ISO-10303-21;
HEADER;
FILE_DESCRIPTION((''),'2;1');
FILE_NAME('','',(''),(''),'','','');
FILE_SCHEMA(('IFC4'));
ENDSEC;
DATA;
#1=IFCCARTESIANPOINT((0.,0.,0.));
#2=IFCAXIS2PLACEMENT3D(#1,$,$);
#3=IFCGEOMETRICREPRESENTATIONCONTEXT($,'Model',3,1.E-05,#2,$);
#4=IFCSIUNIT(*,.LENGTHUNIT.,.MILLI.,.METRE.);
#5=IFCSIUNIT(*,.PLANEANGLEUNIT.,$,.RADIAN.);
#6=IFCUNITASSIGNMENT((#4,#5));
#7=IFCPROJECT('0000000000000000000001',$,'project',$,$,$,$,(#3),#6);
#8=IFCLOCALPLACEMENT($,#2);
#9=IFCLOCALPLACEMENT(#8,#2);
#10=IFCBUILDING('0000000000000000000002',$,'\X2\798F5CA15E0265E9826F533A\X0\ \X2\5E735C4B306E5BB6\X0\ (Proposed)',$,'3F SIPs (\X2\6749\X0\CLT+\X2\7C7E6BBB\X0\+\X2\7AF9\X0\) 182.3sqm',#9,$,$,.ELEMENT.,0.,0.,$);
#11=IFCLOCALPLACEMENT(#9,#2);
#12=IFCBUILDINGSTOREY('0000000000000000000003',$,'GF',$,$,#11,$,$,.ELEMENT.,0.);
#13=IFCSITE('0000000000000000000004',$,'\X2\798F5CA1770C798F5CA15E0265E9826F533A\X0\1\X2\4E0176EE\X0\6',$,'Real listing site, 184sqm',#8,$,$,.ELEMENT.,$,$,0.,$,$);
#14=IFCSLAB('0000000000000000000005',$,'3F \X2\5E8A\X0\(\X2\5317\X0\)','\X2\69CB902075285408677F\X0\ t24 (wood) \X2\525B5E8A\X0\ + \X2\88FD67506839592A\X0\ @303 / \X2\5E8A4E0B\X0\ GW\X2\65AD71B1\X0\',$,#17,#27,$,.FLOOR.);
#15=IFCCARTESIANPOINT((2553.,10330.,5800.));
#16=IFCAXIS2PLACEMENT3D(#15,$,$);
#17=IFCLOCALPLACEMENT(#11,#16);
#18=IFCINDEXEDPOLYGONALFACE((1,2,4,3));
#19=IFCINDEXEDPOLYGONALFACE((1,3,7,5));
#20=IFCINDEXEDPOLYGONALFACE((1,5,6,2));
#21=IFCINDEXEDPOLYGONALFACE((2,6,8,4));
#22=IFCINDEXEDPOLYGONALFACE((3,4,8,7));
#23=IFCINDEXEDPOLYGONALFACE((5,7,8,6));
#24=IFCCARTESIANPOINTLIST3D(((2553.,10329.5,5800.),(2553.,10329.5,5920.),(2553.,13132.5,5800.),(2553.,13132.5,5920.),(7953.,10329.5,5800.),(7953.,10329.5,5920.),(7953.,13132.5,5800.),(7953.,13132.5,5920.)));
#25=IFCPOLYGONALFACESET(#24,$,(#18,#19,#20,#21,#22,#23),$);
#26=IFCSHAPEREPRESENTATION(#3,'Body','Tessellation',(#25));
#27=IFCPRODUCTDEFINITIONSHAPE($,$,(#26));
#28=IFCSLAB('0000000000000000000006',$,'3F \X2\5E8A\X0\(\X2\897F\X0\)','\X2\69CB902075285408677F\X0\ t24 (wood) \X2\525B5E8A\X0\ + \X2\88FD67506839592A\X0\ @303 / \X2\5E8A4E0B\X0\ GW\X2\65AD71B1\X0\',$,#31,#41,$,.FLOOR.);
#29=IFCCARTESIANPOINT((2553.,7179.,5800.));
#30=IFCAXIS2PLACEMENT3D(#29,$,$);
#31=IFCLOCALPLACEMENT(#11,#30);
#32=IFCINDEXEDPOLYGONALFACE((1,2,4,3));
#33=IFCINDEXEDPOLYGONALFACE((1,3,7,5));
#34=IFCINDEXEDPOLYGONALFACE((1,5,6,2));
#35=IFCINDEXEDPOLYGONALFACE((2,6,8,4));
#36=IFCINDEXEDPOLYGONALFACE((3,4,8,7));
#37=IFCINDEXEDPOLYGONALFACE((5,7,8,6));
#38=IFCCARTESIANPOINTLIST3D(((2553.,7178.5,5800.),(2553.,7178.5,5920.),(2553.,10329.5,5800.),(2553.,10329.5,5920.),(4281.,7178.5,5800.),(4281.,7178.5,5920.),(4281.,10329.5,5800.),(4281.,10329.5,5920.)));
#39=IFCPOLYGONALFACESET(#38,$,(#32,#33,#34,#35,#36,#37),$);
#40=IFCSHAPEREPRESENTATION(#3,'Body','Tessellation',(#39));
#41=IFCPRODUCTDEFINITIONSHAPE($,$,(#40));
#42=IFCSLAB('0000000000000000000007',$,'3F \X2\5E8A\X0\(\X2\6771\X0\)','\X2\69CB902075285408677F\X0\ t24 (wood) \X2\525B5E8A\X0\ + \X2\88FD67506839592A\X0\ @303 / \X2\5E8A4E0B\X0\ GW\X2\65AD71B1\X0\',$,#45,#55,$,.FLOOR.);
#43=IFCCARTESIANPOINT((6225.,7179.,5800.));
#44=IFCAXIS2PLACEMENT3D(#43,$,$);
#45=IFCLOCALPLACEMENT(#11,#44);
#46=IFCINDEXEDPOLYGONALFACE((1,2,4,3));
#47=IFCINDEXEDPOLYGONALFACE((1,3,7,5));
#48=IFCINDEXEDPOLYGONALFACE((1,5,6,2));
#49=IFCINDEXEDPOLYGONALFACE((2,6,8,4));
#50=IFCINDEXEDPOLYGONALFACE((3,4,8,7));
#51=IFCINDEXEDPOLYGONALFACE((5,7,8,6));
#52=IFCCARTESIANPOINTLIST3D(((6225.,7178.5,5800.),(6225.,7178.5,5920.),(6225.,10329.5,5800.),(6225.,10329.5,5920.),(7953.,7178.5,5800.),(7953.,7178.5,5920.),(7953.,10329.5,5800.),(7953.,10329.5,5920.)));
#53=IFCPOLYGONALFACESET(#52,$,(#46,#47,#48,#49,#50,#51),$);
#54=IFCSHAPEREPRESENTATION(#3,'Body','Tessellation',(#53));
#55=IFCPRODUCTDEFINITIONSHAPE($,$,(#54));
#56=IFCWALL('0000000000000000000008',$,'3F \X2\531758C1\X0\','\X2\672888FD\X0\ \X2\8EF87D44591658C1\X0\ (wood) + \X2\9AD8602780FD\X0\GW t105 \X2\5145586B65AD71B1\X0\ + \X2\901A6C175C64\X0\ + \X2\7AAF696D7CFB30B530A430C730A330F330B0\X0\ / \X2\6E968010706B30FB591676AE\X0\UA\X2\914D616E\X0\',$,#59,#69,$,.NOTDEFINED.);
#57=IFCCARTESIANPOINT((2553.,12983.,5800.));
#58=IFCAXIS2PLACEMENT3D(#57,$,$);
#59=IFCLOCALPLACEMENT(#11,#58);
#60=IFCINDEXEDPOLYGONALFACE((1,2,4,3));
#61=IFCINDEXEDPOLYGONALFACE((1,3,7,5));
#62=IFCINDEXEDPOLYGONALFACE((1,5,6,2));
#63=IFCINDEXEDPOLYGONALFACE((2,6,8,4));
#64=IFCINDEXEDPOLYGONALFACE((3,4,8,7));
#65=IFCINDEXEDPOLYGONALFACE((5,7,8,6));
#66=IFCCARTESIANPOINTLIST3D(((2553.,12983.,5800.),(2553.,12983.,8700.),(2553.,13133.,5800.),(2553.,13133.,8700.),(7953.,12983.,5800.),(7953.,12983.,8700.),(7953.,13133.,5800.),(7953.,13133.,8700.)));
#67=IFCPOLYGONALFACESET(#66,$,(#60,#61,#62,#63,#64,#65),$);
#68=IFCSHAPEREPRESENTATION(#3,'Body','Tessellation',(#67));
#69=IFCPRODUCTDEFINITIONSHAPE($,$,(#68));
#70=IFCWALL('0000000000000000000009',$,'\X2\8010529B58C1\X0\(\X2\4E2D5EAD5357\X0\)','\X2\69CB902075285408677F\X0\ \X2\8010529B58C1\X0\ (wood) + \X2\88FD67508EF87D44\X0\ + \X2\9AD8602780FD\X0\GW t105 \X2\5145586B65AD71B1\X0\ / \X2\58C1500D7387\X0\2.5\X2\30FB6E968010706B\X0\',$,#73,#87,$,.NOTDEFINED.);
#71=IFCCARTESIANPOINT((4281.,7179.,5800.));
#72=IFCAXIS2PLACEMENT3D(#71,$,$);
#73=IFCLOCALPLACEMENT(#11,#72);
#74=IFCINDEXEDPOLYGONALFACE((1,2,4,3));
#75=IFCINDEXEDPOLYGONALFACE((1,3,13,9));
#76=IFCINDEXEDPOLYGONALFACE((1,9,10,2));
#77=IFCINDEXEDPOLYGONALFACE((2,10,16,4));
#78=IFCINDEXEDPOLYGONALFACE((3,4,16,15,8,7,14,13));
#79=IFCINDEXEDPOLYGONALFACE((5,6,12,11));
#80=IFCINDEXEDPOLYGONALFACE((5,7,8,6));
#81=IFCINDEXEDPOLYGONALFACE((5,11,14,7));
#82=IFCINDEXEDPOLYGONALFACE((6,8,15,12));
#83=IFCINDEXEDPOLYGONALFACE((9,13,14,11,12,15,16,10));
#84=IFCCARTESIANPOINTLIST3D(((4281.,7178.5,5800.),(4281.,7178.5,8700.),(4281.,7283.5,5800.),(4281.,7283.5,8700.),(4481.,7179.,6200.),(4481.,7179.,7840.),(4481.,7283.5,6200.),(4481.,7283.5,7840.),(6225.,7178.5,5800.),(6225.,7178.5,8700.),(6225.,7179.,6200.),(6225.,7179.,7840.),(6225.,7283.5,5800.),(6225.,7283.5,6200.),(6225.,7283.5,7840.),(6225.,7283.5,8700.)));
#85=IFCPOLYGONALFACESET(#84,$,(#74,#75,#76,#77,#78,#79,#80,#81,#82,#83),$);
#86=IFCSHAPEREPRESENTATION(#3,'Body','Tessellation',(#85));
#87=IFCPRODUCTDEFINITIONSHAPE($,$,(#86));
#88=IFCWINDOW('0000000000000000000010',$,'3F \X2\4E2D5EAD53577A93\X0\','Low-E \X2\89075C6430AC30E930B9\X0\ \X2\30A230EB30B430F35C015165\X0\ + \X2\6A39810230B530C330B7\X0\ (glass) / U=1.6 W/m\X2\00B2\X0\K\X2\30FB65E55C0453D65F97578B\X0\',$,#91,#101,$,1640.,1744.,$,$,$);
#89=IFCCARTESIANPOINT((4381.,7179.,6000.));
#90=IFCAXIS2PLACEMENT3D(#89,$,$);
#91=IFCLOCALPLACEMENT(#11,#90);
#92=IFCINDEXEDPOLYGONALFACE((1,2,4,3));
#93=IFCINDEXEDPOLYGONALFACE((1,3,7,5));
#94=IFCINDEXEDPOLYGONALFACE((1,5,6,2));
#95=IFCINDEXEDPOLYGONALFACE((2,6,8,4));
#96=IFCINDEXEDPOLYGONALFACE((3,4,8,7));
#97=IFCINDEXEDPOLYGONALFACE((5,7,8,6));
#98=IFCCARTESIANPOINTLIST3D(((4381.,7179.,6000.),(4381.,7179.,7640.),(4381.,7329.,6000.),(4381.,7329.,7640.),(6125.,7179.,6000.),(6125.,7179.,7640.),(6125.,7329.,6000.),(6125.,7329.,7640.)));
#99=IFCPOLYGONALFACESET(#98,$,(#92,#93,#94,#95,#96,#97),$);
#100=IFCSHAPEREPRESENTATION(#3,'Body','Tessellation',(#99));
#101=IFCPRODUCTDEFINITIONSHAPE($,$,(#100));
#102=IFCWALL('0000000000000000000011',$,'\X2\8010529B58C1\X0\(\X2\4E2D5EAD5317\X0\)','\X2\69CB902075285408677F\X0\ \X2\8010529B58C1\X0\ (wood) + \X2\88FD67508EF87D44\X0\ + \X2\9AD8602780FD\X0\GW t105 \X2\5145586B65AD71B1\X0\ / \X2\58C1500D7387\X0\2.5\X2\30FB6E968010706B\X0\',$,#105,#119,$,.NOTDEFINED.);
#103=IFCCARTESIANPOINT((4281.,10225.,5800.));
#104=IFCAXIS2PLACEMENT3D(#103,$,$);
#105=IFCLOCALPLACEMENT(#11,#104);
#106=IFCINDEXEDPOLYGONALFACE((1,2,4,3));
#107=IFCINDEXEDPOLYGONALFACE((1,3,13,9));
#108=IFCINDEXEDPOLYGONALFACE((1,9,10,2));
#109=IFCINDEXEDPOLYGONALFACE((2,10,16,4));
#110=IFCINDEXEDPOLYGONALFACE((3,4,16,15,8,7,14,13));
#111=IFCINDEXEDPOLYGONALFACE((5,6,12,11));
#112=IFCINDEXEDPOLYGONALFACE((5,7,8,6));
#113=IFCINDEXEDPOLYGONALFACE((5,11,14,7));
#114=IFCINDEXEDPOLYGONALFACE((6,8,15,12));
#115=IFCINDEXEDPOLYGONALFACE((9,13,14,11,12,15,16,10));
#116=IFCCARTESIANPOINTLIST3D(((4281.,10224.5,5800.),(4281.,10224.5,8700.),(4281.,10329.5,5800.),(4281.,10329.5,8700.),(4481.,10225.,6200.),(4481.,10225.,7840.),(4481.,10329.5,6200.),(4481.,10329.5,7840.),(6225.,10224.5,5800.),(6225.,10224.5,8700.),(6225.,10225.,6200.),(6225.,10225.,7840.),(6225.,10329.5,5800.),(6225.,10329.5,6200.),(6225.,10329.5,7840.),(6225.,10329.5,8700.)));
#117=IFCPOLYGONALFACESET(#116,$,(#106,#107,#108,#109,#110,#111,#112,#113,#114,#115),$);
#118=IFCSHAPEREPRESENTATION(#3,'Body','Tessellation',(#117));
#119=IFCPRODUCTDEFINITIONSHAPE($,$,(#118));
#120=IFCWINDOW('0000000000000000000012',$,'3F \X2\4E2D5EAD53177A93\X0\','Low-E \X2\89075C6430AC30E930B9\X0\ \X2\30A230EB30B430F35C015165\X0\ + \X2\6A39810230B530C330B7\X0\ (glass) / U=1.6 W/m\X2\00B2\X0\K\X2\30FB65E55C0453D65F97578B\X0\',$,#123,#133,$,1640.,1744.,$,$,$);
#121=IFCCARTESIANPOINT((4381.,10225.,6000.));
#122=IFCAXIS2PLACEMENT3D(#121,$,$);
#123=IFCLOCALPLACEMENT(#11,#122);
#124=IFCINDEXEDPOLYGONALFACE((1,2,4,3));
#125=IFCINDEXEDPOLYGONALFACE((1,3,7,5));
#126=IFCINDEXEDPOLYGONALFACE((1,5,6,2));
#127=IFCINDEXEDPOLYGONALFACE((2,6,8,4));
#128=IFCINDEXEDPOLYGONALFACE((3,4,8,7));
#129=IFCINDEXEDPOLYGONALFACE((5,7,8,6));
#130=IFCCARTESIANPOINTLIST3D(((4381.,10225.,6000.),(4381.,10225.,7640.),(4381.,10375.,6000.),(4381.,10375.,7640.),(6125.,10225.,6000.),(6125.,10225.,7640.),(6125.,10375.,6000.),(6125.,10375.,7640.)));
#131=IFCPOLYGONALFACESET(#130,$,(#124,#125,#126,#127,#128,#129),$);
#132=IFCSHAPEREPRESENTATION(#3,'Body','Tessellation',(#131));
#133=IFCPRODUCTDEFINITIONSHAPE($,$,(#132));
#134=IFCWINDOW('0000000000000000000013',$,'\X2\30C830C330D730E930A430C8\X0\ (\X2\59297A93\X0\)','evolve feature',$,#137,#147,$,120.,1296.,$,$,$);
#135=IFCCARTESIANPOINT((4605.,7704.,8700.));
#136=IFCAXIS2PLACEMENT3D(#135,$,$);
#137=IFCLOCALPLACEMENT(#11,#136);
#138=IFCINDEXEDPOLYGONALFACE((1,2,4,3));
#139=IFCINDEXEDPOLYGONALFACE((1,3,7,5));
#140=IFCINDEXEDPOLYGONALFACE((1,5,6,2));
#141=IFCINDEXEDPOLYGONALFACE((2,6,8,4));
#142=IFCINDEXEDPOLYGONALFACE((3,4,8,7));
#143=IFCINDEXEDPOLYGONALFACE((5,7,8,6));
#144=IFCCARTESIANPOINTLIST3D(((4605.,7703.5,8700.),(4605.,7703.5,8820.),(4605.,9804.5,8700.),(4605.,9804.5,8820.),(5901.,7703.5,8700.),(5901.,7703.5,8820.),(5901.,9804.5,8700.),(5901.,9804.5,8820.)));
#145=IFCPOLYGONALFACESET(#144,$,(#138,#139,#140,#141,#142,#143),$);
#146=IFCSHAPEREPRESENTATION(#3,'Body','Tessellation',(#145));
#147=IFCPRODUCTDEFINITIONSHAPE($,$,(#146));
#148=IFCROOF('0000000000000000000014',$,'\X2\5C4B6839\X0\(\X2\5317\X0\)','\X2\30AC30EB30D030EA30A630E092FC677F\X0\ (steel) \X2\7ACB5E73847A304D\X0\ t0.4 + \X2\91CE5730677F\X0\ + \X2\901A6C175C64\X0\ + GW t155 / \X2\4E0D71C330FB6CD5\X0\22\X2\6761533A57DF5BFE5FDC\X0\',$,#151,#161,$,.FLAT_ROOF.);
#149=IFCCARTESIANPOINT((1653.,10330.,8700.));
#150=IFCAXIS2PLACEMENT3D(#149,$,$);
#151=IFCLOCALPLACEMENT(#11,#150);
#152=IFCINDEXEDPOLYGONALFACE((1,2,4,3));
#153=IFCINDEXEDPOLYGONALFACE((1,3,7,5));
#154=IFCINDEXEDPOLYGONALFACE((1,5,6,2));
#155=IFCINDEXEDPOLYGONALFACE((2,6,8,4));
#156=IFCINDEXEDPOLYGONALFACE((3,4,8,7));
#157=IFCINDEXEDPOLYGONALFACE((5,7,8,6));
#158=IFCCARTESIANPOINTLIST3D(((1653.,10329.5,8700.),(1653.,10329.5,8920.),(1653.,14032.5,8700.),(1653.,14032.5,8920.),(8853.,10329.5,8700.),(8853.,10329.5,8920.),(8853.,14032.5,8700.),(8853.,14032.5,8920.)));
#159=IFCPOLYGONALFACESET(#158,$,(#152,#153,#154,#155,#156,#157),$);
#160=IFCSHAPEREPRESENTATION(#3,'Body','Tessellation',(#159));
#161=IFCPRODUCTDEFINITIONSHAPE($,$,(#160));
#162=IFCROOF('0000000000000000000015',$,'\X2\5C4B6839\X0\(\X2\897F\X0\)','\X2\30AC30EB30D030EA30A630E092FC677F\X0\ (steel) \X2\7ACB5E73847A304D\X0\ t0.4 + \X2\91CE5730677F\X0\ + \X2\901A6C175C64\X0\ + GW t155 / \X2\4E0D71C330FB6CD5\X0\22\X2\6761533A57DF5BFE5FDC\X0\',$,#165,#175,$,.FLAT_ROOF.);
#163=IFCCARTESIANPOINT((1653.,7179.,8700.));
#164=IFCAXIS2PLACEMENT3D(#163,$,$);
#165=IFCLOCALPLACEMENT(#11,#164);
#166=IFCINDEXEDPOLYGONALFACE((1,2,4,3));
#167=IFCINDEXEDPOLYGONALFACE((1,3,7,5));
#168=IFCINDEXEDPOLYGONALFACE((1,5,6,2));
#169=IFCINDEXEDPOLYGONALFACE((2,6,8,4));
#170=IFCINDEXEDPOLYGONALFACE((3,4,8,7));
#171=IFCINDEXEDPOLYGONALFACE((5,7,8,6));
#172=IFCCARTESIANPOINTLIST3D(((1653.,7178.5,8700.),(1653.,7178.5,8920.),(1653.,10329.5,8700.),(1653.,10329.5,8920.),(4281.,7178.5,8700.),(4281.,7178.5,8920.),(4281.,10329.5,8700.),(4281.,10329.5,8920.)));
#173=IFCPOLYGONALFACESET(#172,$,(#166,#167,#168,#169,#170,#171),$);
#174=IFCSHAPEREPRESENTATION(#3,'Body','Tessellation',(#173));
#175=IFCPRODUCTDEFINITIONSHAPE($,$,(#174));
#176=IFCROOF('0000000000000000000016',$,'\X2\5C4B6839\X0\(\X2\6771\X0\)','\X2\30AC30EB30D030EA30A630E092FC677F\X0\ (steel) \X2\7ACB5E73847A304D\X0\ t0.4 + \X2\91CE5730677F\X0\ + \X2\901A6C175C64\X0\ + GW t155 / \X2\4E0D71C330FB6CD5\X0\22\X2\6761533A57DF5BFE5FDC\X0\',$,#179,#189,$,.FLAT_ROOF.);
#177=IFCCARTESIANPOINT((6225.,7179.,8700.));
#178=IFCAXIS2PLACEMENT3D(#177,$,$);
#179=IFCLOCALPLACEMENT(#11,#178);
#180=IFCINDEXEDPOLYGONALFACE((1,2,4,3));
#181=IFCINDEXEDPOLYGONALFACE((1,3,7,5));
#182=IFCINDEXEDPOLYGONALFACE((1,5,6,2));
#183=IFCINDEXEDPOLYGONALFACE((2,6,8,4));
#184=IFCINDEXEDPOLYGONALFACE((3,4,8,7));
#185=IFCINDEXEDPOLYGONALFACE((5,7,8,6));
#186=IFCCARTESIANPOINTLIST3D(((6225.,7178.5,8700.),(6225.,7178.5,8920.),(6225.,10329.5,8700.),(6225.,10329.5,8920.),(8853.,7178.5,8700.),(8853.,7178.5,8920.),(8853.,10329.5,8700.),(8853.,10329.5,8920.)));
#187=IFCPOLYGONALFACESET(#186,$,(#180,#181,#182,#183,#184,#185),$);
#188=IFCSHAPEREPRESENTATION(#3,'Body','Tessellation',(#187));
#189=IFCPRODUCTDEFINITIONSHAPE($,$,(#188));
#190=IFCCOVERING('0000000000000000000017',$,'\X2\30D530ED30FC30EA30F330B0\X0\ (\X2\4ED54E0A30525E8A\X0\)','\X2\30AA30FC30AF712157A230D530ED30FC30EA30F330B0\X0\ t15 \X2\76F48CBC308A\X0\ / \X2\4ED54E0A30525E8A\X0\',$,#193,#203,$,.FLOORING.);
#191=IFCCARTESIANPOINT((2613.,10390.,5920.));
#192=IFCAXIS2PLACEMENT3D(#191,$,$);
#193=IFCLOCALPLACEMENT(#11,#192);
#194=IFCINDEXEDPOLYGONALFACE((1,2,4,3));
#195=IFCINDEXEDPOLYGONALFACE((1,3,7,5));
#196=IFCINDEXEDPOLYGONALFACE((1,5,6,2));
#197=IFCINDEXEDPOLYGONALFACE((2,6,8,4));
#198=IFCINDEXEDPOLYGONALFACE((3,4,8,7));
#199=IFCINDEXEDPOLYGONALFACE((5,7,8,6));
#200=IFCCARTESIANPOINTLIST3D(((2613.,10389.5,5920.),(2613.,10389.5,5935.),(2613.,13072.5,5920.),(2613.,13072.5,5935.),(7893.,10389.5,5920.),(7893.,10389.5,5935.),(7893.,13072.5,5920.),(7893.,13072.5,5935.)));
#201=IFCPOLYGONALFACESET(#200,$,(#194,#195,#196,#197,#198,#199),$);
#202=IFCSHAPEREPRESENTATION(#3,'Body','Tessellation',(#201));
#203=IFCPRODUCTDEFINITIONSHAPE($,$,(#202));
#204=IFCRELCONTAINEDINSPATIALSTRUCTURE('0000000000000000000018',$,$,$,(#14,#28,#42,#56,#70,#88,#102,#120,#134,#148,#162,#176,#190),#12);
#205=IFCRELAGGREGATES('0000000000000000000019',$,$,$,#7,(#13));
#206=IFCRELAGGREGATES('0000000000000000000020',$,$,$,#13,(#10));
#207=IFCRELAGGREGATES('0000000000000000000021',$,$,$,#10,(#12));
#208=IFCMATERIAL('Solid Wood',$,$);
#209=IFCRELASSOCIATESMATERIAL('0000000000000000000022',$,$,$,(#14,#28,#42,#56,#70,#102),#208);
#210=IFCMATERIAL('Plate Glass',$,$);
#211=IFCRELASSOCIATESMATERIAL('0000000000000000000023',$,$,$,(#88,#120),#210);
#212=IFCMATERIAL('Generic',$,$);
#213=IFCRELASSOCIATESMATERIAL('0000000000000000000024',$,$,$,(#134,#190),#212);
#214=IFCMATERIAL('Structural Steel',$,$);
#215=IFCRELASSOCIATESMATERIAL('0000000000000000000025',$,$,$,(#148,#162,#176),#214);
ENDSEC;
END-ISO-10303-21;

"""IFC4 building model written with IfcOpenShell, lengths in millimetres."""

from ifc_helpers import new_model, si_unit, frame, frame_2d, origin, place, context, project, spatial, rectangle, extrude, material, element, fill, save


model = new_model("IFC4")

# Units and contexts
model_context = context("Model", 3, precision=1e-05, world=origin())
ifc_project = project(units=[si_unit("LENGTHUNIT", "METRE", prefix="MILLI"), si_unit("PLANEANGLEUNIT", "RADIAN")], contexts=[model_context])

# Site, building, storey
site_placement = place(None, origin())
site = spatial("IfcSite", under=ifc_project, at=site_placement, Name="福岡県福岡市早良区1丁目6", ObjectType="Real listing site, 184sqm", CompositionType="ELEMENT", RefElevation=0.0)
building_placement = place(site_placement, origin())
building = spatial("IfcBuilding", under=site, at=building_placement, Name="福岡市早良区 平屋の家 (Proposed)", ObjectType="3F SIPs (杉CLT+籾殻+竹) 182.3sqm", CompositionType="ELEMENT", ElevationOfRefHeight=0.0, ElevationOfTerrain=0.0)
storey_placement = place(building_placement, origin())
storey = spatial("IfcBuildingStorey", under=building, at=storey_placement, Name="GF", CompositionType="ELEMENT", Elevation=0.0)

# Slabs
ifc_material_1 = material(Name="Solid Wood")
slab_1_placement = place(storey_placement, frame((2553.0, 10330.0, 5800.0)))
element("IfcSlab", 1, at=slab_1_placement, inside=storey, material=ifc_material_1, Name="3F 床(北)", Description="構造用合板 t24 (wood) 剛床 + 製材根太 @303 / 床下 GW断熱", PredefinedType="FLOOR", context=model_context, shape_type="SweptSolid", body=[
    extrude(rectangle(XDim=5400.0, YDim=2803.0, at=frame_2d((2700.0, 1401.0))), frame((2553.0, 10330.0, 5800.0)), (0.0, 0.0, 1.0), 120.0),
])
slab_2_placement = place(storey_placement, frame((2553.0, 7179.0, 5800.0)))
element("IfcSlab", 2, at=slab_2_placement, inside=storey, material=ifc_material_1, Name="3F 床(西)", Description="構造用合板 t24 (wood) 剛床 + 製材根太 @303 / 床下 GW断熱", PredefinedType="FLOOR", context=model_context, shape_type="SweptSolid", body=[
    extrude(rectangle(XDim=1728.0, YDim=3151.0, at=frame_2d((864.0, 1575.0))), frame((2553.0, 7179.0, 5800.0)), (0.0, 0.0, 1.0), 120.0),
])
slab_3_placement = place(storey_placement, frame((6225.0, 7179.0, 5800.0)))
element("IfcSlab", 3, at=slab_3_placement, inside=storey, material=ifc_material_1, Name="3F 床(東)", Description="構造用合板 t24 (wood) 剛床 + 製材根太 @303 / 床下 GW断熱", PredefinedType="FLOOR", context=model_context, shape_type="SweptSolid", body=[
    extrude(rectangle(XDim=1728.0, YDim=3151.0, at=frame_2d((864.0, 1575.0))), frame((6225.0, 7179.0, 5800.0)), (0.0, 0.0, 1.0), 120.0),
])

# Wall
wall_1_placement = place(storey_placement, frame((2553.0, 12983.0, 5800.0)))
element("IfcWall", 4, at=wall_1_placement, inside=storey, material=ifc_material_1, Name="3F 北壁", Description="木製 軸組外壁 (wood) + 高性能GW t105 充填断熱 + 通気層 + 窯業系サイディング / 準耐火・外皮UA配慮", PredefinedType="NOTDEFINED", context=model_context, shape_type="SweptSolid", body=[
    extrude(rectangle(XDim=5400.0, YDim=150.0, at=frame_2d((2700.0, 75.0))), frame((2553.0, 12983.0, 5800.0)), (0.0, 0.0, 1.0), 2900.0),
])

# Walls, openings, windows
wall_2_placement = place(storey_placement, frame((4281.0, 7179.0, 5800.0)))
wall_2 = element("IfcWall", 5, at=wall_2_placement, inside=storey, material=ifc_material_1, Name="耐力壁(中庭南)", Description="構造用合板 耐力壁 (wood) + 製材軸組 + 高性能GW t105 充填断熱 / 壁倍率2.5・準耐火", PredefinedType="NOTDEFINED", context=model_context, shape_type="SweptSolid", body=[
    extrude(rectangle(XDim=1944.0, YDim=105.0, at=frame_2d((972.0, 52.0))), frame((4281.0, 7179.0, 5800.0)), (0.0, 0.0, 1.0), 2900.0),
])
opening_1_placement = place(storey_placement, frame((4381.0, 7179.0, 6000.0)))
opening_1 = element("IfcOpeningElement", 6, at=opening_1_placement, cuts=wall_2, PredefinedType="NOTDEFINED", context=model_context, shape_type="SweptSolid", body=[
    extrude(rectangle(XDim=1744.0, YDim=150.0, at=frame_2d((872.0, 75.0))), frame((4381.0, 7179.0, 6000.0)), (0.0, 0.0, 1.0), 1640.0),
])
ifc_material_2 = material(Name="Plate Glass")
window_1_placement = place(storey_placement, frame((4381.0, 7179.0, 6000.0)))
window_1 = element("IfcWindow", 7, at=window_1_placement, inside=storey, material=ifc_material_2, Name="3F 中庭南窓", Description="Low-E 複層ガラス アルゴン封入 + 樹脂サッシ (glass) / U=1.6 W/m²K・日射取得型", OverallHeight=1640.0, OverallWidth=1744.0, context=model_context, shape_type="SweptSolid", body=[
    extrude(rectangle(XDim=1744.0, YDim=150.0, at=frame_2d((872.0, 75.0))), frame((4381.0, 7179.0, 6000.0)), (0.0, 0.0, 1.0), 1640.0),
])
fill(opening_1, window_1)
wall_3_placement = place(storey_placement, frame((4281.0, 10225.0, 5800.0)))
wall_3 = element("IfcWall", 8, at=wall_3_placement, inside=storey, material=ifc_material_1, Name="耐力壁(中庭北)", Description="構造用合板 耐力壁 (wood) + 製材軸組 + 高性能GW t105 充填断熱 / 壁倍率2.5・準耐火", PredefinedType="NOTDEFINED", context=model_context, shape_type="SweptSolid", body=[
    extrude(rectangle(XDim=1944.0, YDim=105.0, at=frame_2d((972.0, 52.0))), frame((4281.0, 10225.0, 5800.0)), (0.0, 0.0, 1.0), 2900.0),
])
opening_2_placement = place(storey_placement, frame((4381.0, 10225.0, 6000.0)))
opening_2 = element("IfcOpeningElement", 9, at=opening_2_placement, cuts=wall_3, PredefinedType="NOTDEFINED", context=model_context, shape_type="SweptSolid", body=[
    extrude(rectangle(XDim=1744.0, YDim=150.0, at=frame_2d((872.0, 75.0))), frame((4381.0, 10225.0, 6000.0)), (0.0, 0.0, 1.0), 1640.0),
])
window_2_placement = place(storey_placement, frame((4381.0, 10225.0, 6000.0)))
window_2 = element("IfcWindow", 10, at=window_2_placement, inside=storey, material=ifc_material_2, Name="3F 中庭北窓", Description="Low-E 複層ガラス アルゴン封入 + 樹脂サッシ (glass) / U=1.6 W/m²K・日射取得型", OverallHeight=1640.0, OverallWidth=1744.0, context=model_context, shape_type="SweptSolid", body=[
    extrude(rectangle(XDim=1744.0, YDim=150.0, at=frame_2d((872.0, 75.0))), frame((4381.0, 10225.0, 6000.0)), (0.0, 0.0, 1.0), 1640.0),
])
fill(opening_2, window_2)

# Window
ifc_material_3 = material(Name="Generic")
window_3_placement = place(storey_placement, frame((4605.0, 7704.0, 8700.0)))
element("IfcWindow", 11, at=window_3_placement, inside=storey, material=ifc_material_3, Name="トップライト (天窓)", Description="evolve feature", OverallHeight=120.0, OverallWidth=1296.0, context=model_context, shape_type="SweptSolid", body=[
    extrude(rectangle(XDim=1296.0, YDim=2101.0, at=frame_2d((648.0, 1050.0))), frame((4605.0, 7704.0, 8700.0)), (0.0, 0.0, 1.0), 120.0),
])

# Roofs
ifc_material_4 = material(Name="Structural Steel")
for number, where, name in (
    (12, (1653.0, 10330.0, 8700.0), "屋根(北)"),
):
    element("IfcRoof", number, at=place(storey_placement, frame(where)), inside=storey, material=ifc_material_4, Name=name, Description="ガルバリウム鋼板 (steel) 立平葺き t0.4 + 野地板 + 通気層 + GW t155 / 不燃・法22条区域対応", PredefinedType="FLAT_ROOF", context=model_context, shape_type="SweptSolid", body=[
        extrude(rectangle(XDim=7200.0, YDim=3703.0, at=frame_2d((3600.0, 1851.0))), frame((1653.0, 10330.0, 8700.0)), (0.0, 0.0, 1.0), 220.0),
    ])
roof_1_placement = place(storey_placement, frame((1653.0, 7179.0, 8700.0)))
element("IfcRoof", 13, at=roof_1_placement, inside=storey, material=ifc_material_4, Name="屋根(西)", Description="ガルバリウム鋼板 (steel) 立平葺き t0.4 + 野地板 + 通気層 + GW t155 / 不燃・法22条区域対応", PredefinedType="FLAT_ROOF", context=model_context, shape_type="SweptSolid", body=[
    extrude(rectangle(XDim=2628.0, YDim=3151.0, at=frame_2d((1314.0, 1575.0))), frame((1653.0, 7179.0, 8700.0)), (0.0, 0.0, 1.0), 220.0),
])
roof_2_placement = place(storey_placement, frame((6225.0, 7179.0, 8700.0)))
element("IfcRoof", 14, at=roof_2_placement, inside=storey, material=ifc_material_4, Name="屋根(東)", Description="ガルバリウム鋼板 (steel) 立平葺き t0.4 + 野地板 + 通気層 + GW t155 / 不燃・法22条区域対応", PredefinedType="FLAT_ROOF", context=model_context, shape_type="SweptSolid", body=[
    extrude(rectangle(XDim=2628.0, YDim=3151.0, at=frame_2d((1314.0, 1575.0))), frame((6225.0, 7179.0, 8700.0)), (0.0, 0.0, 1.0), 220.0),
])

# Covering
covering_1_placement = place(storey_placement, frame((2613.0, 10390.0, 5920.0)))
element("IfcCovering", 15, at=covering_1_placement, inside=storey, material=ifc_material_3, Name="フローリング (仕上げ床)", Description="オーク無垢フローリング t15 直貼り / 仕上げ床", PredefinedType="FLOORING", context=model_context, shape_type="SweptSolid", body=[
    extrude(rectangle(XDim=5280.0, YDim=2683.0, at=frame_2d((2640.0, 1341.0))), frame((2613.0, 10390.0, 5920.0)), (0.0, 0.0, 1.0), 15.0),
])

save(model, "model.ifc")
